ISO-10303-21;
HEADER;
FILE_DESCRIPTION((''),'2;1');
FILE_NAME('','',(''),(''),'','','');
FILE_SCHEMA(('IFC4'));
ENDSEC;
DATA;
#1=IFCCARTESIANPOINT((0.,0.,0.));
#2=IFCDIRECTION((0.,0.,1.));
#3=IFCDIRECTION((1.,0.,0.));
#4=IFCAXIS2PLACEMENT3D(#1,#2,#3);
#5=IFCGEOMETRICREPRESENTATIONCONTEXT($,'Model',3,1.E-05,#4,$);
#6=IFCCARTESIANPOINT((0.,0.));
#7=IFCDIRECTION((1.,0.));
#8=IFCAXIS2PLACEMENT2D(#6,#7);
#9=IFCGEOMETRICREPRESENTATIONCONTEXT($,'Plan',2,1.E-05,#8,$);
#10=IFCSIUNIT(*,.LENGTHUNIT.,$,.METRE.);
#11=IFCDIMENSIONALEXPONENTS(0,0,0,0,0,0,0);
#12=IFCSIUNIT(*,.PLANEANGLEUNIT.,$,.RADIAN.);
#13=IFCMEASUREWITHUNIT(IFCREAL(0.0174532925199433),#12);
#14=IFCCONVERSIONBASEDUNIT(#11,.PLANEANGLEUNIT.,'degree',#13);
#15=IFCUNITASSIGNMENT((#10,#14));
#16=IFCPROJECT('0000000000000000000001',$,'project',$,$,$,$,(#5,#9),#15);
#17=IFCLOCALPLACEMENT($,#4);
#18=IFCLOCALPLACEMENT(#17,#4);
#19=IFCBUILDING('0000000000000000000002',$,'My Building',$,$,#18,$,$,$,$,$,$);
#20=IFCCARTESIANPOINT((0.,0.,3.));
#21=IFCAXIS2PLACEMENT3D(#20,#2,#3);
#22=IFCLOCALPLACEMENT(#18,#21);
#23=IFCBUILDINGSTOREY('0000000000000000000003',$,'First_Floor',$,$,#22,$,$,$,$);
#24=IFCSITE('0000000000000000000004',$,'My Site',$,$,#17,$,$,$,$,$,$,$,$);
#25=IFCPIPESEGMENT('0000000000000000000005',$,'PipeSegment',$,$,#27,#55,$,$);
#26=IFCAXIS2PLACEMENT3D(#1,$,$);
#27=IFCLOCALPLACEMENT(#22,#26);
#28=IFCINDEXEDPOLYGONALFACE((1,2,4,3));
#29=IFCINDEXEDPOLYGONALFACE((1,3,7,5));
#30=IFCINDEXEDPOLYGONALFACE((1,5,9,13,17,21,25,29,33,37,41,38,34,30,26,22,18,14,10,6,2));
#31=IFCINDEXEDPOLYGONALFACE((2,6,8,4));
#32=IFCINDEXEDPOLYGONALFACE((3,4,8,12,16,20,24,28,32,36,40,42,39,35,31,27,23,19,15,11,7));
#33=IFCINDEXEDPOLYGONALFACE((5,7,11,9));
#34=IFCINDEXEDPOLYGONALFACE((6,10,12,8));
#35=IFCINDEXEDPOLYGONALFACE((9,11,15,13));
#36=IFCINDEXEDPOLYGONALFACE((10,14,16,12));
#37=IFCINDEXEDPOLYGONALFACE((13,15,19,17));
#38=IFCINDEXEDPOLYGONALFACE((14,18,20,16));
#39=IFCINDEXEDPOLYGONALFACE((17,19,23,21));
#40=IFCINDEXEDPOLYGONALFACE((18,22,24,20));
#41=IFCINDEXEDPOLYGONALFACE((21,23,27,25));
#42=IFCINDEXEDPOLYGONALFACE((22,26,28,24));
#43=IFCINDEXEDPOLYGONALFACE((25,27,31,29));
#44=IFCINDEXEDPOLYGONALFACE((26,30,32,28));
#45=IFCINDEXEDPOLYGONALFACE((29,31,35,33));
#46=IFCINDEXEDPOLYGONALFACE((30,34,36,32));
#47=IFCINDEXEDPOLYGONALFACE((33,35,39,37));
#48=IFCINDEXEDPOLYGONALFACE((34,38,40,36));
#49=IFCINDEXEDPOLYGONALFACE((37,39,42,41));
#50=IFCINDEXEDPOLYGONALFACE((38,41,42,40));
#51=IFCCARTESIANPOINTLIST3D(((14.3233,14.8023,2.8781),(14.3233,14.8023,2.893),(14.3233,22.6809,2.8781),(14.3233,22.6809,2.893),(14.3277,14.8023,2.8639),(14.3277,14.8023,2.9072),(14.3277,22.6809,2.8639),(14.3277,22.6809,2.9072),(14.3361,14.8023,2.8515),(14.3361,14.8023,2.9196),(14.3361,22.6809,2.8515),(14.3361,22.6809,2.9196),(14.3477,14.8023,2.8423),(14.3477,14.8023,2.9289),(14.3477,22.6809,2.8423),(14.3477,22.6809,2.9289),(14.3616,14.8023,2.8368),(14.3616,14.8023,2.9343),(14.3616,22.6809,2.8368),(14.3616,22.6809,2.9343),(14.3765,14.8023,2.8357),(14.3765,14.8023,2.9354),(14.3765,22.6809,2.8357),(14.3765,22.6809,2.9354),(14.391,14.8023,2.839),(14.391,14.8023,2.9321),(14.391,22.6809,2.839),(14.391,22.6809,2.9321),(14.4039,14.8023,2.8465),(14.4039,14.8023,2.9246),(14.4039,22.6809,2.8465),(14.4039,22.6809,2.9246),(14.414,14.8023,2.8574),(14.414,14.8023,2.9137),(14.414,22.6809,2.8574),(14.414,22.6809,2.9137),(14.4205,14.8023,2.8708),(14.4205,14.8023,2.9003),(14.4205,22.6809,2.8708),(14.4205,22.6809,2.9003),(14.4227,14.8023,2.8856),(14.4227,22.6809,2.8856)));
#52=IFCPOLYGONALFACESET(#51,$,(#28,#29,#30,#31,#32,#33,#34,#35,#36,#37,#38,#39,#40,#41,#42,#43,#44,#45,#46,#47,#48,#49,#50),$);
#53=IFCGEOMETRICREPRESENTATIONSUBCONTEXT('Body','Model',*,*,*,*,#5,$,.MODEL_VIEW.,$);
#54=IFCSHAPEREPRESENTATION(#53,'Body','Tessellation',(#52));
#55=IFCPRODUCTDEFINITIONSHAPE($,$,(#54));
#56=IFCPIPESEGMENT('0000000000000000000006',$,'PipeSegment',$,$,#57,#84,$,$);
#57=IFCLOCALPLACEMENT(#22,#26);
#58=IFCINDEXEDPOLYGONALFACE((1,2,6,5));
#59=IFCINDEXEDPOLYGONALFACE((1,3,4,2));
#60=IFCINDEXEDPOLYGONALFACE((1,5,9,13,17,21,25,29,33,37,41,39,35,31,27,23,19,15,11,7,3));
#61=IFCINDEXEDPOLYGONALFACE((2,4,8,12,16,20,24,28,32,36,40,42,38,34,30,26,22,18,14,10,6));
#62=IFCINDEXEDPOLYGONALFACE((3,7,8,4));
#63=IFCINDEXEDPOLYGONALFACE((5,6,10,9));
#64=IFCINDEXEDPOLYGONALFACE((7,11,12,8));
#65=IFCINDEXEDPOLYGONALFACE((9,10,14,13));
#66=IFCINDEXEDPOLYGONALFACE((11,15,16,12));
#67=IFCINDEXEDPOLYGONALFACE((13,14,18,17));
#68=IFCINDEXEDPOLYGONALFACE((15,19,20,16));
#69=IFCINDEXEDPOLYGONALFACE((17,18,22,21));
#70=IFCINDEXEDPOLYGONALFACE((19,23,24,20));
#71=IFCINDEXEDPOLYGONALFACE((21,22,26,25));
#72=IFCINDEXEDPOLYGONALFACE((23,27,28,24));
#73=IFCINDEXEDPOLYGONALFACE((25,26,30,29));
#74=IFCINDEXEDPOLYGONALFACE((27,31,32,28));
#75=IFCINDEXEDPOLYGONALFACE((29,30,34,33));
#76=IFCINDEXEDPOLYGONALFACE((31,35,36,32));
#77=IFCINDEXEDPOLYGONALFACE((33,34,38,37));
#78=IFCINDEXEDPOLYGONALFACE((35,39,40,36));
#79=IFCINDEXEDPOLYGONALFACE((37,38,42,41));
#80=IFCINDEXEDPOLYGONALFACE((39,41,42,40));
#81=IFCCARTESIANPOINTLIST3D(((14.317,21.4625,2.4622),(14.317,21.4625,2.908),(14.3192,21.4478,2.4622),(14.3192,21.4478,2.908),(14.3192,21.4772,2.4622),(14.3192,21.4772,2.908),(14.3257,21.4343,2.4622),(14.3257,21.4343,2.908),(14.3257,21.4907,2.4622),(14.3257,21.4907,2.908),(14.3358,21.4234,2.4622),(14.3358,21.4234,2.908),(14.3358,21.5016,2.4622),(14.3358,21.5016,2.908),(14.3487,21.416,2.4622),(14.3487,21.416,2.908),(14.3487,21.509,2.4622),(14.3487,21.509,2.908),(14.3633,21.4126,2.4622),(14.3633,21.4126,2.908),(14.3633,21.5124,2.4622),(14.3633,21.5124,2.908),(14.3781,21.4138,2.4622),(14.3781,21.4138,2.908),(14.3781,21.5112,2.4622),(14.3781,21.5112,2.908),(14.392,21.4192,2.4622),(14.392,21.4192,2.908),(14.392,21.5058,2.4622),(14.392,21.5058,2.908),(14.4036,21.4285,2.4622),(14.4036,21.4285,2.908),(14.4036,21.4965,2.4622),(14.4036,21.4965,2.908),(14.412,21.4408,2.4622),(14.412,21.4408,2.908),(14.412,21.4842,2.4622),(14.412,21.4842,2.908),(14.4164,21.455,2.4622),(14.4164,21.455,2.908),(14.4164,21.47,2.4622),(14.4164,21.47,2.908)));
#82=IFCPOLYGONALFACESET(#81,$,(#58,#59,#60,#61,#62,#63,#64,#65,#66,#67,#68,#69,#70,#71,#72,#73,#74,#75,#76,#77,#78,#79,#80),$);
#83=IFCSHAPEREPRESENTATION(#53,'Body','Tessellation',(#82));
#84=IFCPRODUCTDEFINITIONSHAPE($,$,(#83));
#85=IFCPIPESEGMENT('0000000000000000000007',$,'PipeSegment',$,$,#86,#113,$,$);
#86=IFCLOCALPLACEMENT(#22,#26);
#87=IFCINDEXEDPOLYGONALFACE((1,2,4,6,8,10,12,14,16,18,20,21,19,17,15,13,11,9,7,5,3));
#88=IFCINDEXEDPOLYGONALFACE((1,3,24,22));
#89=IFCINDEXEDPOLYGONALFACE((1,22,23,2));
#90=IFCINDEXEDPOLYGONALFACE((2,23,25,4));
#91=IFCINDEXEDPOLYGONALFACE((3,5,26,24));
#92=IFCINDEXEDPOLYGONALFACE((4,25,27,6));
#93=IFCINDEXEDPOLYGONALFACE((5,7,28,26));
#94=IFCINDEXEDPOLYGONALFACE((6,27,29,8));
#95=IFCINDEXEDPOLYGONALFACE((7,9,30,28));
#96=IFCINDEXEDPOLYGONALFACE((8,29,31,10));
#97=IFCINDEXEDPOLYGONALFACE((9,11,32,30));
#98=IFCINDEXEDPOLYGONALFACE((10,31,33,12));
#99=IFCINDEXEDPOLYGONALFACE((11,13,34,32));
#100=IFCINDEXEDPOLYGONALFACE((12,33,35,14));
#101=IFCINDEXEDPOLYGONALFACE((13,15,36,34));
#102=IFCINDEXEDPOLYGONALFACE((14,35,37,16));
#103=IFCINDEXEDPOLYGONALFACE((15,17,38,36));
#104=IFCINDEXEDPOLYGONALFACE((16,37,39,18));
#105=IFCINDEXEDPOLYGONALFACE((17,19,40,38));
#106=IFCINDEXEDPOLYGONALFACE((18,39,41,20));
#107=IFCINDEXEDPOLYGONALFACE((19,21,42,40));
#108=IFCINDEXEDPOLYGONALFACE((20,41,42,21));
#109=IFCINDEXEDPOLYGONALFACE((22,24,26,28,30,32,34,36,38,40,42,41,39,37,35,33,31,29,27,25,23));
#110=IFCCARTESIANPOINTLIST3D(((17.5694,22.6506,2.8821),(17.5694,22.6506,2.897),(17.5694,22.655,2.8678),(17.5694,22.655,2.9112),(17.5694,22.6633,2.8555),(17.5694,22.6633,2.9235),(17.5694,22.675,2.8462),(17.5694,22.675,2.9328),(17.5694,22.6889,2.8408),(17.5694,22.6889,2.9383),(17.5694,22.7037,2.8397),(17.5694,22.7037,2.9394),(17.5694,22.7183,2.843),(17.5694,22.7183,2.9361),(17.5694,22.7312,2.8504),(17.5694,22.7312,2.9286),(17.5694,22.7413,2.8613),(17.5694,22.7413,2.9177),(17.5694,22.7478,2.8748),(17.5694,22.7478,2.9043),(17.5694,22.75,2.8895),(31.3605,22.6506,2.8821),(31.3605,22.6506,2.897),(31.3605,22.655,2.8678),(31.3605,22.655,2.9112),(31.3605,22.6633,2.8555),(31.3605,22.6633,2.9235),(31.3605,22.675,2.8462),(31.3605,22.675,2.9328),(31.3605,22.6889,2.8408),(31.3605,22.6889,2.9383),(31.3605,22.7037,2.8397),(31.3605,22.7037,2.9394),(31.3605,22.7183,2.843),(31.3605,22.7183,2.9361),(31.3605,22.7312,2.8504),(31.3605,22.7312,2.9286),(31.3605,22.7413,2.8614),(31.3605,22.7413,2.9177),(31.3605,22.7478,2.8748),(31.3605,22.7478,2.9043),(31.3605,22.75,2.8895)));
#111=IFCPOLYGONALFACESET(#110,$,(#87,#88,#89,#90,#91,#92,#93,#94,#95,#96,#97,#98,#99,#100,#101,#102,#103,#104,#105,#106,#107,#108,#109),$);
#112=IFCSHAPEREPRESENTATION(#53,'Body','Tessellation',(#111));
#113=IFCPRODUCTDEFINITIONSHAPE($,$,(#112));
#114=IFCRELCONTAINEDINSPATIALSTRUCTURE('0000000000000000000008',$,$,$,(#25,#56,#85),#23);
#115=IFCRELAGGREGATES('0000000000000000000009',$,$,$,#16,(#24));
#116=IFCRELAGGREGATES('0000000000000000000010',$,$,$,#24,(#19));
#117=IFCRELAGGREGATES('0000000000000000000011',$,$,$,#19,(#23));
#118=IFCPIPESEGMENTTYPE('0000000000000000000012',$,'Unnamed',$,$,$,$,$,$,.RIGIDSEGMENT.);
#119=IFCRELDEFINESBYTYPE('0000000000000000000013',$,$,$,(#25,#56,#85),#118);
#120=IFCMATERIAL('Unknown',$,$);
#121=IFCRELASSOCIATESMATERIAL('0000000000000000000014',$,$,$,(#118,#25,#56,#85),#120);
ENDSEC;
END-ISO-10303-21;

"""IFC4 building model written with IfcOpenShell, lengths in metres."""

from ifc_helpers import new_model, entity, si_unit, converted_unit, frame, origin_with_axes, origin_2d_with_axis, place, context, subcontext, project, spatial, circle, extrude, material, material_profile, profile_set, profile_usage, type_object, element, save


model = new_model("IFC4")

# Units and contexts
model_context = context("Model", 3, precision=1e-05, world=origin_with_axes())
plan_context = context("Plan", 2, precision=1e-05, world=origin_2d_with_axis())
body_context = subcontext(model_context, "Body", "Model", "MODEL_VIEW")
ifc_project = project(units=[si_unit("LENGTHUNIT", "METRE"), converted_unit("PLANEANGLEUNIT", "degree", entity("IfcReal", 0.0174532925199433), si_unit("PLANEANGLEUNIT", "RADIAN"), dimensions=[0, 0, 0, 0, 0, 0, 0])], contexts=[model_context, plan_context])

# Site, building, storey
site_placement = place(None, origin_with_axes())
site = spatial("IfcSite", under=ifc_project, at=site_placement, Name="My Site")
building_placement = place(site_placement, origin_with_axes())
building = spatial("IfcBuilding", under=site, at=building_placement, Name="My Building")
storey_placement = place(building_placement, frame((0.0, 0.0, 3.0), z_axis=(0.0, 0.0, 1.0), x_axis=(1.0, 0.0, 0.0)))
storey = spatial("IfcBuildingStorey", under=building, at=storey_placement, Name="First_Floor")

# Shared definitions
ifc_material = material(Name="Unknown")

# Pipe segments
ifc_material_profile_1 = material_profile(ifc_material, circle(Radius=0.05))
ifc_profile_set_1 = profile_set([ifc_material_profile_1])
pipe_segment_type = type_object("IfcPipeSegmentType", Name="Unnamed", PredefinedType="RIGIDSEGMENT", material=ifc_profile_set_1)
ifc_profile_usage_1 = profile_usage(ifc_profile_set_1, cardinal=5)
pipe_segment_1_placement = place(storey_placement, frame((14.3727, 22.6809, 2.8856), z_axis=(0.0, -1.0, 0.0), x_axis=(1.0, 0.0, 0.0)))
element("IfcPipeSegment", 1, at=pipe_segment_1_placement, inside=storey, type_object=pipe_segment_type, material=ifc_profile_usage_1, Name="PipeSegment", context=body_context, shape_type="SweptSolid", body=[
    extrude(circle(Radius=0.05), origin_with_axes(), (0.0, 0.0, 1.0), 7.8786),
])
ifc_profile_usage_2 = profile_usage(ifc_profile_set_1, cardinal=5)
pipe_segment_2_placement = place(storey_placement, frame((14.367, 21.4625, 2.908), z_axis=(0.0, 0.0, -1.0), x_axis=(-1.0, 0.0, 0.0)))
element("IfcPipeSegment", 2, at=pipe_segment_2_placement, inside=storey, type_object=pipe_segment_type, material=ifc_profile_usage_2, Name="PipeSegment", context=body_context, shape_type="SweptSolid", body=[
    extrude(circle(Radius=0.05), origin_with_axes(), (0.0, 0.0, 1.0), 0.4458),
])
ifc_profile_usage_3 = profile_usage(ifc_profile_set_1, cardinal=1)
pipe_segment_3_placement = place(storey_placement, frame((17.5694, 22.75, 2.8395), z_axis=(1.0, 0.0, 0.0), x_axis=(0.0, 1.0, 0.0)))
element("IfcPipeSegment", 3, at=pipe_segment_3_placement, inside=storey, type_object=pipe_segment_type, material=ifc_profile_usage_3, Name="PipeSegment", context=body_context, shape_type="SweptSolid", body=[
    extrude(circle(Radius=0.05), frame((-0.05, 0.05, 0.0), z_axis=(0.0, 0.0, 1.0), x_axis=(1.0, 0.0, 0.0)), (0.0, 0.0, 1.0), 13.7911),
])

save(model, "model.ifc")
